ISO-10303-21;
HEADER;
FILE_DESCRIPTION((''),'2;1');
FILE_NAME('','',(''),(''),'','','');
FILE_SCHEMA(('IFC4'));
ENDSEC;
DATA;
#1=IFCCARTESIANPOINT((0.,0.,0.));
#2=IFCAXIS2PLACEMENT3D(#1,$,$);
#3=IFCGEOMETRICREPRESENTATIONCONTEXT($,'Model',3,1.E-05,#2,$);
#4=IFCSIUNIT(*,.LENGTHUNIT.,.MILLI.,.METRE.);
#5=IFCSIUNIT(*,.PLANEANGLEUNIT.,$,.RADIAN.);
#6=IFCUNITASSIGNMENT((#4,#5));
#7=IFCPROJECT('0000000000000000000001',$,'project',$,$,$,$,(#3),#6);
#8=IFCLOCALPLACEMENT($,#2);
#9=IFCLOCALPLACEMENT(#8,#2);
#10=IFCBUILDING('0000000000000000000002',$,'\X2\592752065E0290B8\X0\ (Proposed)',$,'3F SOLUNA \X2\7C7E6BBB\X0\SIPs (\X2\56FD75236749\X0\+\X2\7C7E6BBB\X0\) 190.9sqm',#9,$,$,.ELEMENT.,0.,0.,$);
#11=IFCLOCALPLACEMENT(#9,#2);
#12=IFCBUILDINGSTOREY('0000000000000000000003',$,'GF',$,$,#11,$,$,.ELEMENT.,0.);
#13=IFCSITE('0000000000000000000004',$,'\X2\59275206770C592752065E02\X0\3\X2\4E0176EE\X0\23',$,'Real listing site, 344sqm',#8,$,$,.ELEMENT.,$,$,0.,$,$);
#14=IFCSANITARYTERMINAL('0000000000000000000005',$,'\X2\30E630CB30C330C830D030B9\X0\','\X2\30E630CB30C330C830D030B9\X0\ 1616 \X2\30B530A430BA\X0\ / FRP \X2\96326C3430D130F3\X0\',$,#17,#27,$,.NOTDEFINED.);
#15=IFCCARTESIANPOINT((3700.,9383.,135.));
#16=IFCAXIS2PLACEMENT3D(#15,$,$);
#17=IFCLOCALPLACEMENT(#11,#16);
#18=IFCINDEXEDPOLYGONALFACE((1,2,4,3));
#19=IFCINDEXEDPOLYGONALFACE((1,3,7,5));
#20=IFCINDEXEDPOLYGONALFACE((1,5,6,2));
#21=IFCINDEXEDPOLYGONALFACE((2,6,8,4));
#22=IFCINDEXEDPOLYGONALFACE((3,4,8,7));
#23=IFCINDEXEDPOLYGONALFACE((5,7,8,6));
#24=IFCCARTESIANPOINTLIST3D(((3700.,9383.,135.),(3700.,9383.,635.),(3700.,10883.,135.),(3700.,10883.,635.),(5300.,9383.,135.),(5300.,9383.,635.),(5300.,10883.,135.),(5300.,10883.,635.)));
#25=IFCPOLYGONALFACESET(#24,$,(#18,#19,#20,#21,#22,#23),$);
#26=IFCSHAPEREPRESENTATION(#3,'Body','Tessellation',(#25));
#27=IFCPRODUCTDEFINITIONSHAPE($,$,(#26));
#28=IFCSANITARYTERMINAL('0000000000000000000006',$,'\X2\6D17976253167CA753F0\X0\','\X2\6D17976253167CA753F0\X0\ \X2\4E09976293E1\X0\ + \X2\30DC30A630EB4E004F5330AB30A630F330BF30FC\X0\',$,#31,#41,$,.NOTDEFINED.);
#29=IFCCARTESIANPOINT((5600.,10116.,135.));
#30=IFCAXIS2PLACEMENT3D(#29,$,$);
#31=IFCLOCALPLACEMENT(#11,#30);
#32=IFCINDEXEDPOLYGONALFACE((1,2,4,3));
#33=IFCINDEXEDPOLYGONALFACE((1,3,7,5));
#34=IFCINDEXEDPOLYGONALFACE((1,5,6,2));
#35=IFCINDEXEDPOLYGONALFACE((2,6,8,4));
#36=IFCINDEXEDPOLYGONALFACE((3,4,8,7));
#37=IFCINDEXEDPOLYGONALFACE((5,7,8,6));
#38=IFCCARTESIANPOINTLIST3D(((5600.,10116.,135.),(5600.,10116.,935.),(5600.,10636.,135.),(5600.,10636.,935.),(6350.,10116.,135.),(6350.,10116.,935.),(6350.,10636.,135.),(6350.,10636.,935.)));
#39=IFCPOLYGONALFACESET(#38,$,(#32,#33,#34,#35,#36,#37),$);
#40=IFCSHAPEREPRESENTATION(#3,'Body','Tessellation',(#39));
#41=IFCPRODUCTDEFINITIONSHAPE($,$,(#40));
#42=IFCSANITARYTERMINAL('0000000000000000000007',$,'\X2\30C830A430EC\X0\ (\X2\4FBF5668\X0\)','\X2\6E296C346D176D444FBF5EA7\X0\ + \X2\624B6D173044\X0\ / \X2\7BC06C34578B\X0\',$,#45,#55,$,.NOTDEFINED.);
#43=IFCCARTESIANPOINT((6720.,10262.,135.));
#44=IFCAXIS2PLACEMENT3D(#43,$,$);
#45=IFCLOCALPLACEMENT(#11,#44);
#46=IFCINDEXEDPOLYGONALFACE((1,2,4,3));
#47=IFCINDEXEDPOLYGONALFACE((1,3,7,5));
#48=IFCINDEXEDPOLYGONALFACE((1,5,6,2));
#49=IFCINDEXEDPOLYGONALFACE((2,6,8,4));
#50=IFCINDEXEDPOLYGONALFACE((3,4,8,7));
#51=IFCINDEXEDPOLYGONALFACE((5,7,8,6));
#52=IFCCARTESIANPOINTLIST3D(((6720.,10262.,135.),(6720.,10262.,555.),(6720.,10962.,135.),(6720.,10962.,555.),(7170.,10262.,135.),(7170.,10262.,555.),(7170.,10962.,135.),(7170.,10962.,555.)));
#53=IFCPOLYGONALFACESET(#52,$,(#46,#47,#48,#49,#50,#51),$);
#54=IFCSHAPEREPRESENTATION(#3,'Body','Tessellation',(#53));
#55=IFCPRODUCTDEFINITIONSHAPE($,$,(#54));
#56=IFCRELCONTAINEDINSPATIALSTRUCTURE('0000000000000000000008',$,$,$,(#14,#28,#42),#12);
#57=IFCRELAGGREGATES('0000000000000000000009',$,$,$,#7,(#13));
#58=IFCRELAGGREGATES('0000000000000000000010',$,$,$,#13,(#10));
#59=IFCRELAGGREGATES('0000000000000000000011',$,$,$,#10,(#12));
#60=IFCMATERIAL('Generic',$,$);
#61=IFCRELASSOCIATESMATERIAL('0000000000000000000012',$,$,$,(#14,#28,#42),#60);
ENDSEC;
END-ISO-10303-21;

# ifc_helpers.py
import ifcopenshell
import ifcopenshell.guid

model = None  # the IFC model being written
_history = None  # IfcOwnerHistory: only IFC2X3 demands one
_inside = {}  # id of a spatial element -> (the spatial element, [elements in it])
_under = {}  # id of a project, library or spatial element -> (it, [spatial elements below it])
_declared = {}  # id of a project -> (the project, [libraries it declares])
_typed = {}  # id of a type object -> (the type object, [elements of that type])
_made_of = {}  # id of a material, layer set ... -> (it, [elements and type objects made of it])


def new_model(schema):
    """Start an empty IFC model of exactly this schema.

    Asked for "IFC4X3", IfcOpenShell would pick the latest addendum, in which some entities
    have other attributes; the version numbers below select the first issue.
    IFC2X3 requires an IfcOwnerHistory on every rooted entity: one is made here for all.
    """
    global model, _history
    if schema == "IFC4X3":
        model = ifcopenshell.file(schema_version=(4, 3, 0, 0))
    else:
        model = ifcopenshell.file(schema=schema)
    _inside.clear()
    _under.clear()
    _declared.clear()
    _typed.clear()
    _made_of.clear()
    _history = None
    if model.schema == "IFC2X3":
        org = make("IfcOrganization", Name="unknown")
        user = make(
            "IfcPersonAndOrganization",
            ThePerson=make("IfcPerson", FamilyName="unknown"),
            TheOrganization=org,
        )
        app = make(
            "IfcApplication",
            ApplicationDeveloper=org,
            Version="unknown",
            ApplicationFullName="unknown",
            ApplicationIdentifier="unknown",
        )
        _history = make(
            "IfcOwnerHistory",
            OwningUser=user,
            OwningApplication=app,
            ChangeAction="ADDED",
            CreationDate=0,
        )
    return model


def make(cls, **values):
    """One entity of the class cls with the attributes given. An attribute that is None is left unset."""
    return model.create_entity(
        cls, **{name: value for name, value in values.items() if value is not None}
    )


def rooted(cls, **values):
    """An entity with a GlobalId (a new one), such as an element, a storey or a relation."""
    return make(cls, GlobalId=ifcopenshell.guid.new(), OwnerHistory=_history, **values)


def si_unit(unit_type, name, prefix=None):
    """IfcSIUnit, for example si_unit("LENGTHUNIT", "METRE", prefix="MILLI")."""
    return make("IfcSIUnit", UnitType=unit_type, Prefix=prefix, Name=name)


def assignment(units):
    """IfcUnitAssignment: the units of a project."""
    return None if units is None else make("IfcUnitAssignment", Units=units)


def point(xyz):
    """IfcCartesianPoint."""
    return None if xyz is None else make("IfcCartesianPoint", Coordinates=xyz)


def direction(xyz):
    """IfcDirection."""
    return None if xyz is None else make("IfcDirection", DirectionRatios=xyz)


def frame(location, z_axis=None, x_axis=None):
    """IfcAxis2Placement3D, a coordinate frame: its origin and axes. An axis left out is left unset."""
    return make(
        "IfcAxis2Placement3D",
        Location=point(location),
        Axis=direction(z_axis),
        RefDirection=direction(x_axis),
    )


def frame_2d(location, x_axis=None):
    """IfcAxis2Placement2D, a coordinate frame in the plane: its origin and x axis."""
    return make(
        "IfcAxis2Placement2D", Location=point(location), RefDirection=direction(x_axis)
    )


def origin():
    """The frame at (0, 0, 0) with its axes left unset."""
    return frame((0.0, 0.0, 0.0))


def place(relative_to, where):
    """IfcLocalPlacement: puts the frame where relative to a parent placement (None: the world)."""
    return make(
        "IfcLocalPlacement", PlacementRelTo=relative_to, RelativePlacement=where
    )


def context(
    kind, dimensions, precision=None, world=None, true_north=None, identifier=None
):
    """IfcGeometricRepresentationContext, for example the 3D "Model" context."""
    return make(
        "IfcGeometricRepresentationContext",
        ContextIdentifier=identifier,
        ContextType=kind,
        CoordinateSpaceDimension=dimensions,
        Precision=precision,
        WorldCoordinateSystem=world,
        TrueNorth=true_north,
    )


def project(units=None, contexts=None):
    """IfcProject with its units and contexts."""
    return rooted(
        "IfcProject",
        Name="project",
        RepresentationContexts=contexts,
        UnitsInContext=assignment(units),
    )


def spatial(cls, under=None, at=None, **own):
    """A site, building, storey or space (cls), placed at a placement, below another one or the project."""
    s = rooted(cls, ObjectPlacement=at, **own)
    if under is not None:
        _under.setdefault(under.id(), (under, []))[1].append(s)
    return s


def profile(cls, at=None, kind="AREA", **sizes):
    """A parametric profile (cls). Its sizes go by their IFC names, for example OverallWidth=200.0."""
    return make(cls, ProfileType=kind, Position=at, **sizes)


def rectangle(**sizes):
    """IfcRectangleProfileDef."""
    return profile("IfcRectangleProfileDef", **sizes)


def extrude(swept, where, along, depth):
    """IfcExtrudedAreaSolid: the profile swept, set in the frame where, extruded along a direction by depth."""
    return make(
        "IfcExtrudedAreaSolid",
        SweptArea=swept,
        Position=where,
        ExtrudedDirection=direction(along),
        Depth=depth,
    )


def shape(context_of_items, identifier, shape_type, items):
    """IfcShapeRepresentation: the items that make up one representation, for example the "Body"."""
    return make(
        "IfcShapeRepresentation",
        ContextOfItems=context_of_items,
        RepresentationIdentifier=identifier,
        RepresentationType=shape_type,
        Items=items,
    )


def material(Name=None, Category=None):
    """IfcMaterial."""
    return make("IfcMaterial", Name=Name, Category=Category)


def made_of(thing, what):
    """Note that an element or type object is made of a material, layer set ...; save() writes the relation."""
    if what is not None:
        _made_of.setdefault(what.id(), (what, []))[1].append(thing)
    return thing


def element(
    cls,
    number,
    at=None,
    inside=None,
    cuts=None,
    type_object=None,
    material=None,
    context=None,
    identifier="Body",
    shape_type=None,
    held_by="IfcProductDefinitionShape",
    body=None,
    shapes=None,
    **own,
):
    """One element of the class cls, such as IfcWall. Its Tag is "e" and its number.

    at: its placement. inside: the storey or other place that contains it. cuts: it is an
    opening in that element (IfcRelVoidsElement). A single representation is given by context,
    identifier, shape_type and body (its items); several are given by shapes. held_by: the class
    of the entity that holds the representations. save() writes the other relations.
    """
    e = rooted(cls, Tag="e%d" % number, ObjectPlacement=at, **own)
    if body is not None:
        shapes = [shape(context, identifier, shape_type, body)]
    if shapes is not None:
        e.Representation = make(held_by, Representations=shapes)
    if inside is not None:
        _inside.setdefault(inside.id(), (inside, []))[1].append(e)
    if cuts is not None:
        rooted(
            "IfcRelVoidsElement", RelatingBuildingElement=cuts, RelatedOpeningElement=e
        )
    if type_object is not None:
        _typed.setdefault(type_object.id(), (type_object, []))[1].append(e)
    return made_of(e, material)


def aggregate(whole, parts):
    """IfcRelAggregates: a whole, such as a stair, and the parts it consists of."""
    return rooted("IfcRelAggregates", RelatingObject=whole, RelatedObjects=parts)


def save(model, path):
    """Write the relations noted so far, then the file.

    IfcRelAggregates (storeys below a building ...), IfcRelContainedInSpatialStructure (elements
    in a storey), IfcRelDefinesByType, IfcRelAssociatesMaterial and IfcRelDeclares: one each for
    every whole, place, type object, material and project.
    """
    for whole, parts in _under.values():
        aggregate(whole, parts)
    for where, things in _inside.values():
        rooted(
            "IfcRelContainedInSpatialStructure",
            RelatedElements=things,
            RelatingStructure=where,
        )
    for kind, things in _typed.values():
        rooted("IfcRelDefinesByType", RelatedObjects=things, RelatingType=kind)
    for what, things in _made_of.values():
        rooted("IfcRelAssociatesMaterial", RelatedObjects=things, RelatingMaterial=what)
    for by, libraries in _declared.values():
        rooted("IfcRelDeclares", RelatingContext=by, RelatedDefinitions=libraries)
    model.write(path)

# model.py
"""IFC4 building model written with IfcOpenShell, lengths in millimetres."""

from ifc_helpers import new_model, si_unit, frame, frame_2d, origin, place, context, project, spatial, rectangle, extrude, material, element, save


model = new_model("IFC4")

# Units and contexts
model_context = context("Model", 3, precision=1e-05, world=origin())
ifc_project = project(units=[si_unit("LENGTHUNIT", "METRE", prefix="MILLI"), si_unit("PLANEANGLEUNIT", "RADIAN")], contexts=[model_context])

# Site, building, storey
site_placement = place(None, origin())
site = spatial("IfcSite", under=ifc_project, at=site_placement, Name="大分県大分市3丁目23", ObjectType="Real listing site, 344sqm", CompositionType="ELEMENT", RefElevation=0.0)
building_placement = place(site_placement, origin())
building = spatial("IfcBuilding", under=site, at=building_placement, Name="大分市邸 (Proposed)", ObjectType="3F SOLUNA 籾殻SIPs (国産杉+籾殻) 190.9sqm", CompositionType="ELEMENT", ElevationOfRefHeight=0.0, ElevationOfTerrain=0.0)
storey_placement = place(building_placement, origin())
storey = spatial("IfcBuildingStorey", under=building, at=storey_placement, Name="GF", CompositionType="ELEMENT", Elevation=0.0)

# Shared definitions
ifc_material_1 = material(Name="Generic")

# Sanitary terminals
sanitary_terminal_1_placement = place(storey_placement, frame((3700.0, 9383.0, 135.0)))
element("IfcSanitaryTerminal", 1, at=sanitary_terminal_1_placement, inside=storey, material=ifc_material_1, Name="ユニットバス", Description="ユニットバス 1616 サイズ / FRP 防水パン", PredefinedType="NOTDEFINED", context=model_context, shape_type="SweptSolid", body=[
    extrude(rectangle(XDim=1600.0, YDim=1500.0, at=frame_2d((800.0, 750.0))), frame((3700.0, 9383.0, 135.0)), (0.0, 0.0, 1.0), 500.0),
])
sanitary_terminal_2_placement = place(storey_placement, frame((5600.0, 10116.0, 135.0)))
element("IfcSanitaryTerminal", 2, at=sanitary_terminal_2_placement, inside=storey, material=ifc_material_1, Name="洗面化粧台", Description="洗面化粧台 三面鏡 + ボウル一体カウンター", PredefinedType="NOTDEFINED", context=model_context, shape_type="SweptSolid", body=[
    extrude(rectangle(XDim=750.0, YDim=520.0, at=frame_2d((375.0, 260.0))), frame((5600.0, 10116.0, 135.0)), (0.0, 0.0, 1.0), 800.0),
])
sanitary_terminal_3_placement = place(storey_placement, frame((6720.0, 10262.0, 135.0)))
element("IfcSanitaryTerminal", 3, at=sanitary_terminal_3_placement, inside=storey, material=ifc_material_1, Name="トイレ (便器)", Description="温水洗浄便座 + 手洗い / 節水型", PredefinedType="NOTDEFINED", context=model_context, shape_type="SweptSolid", body=[
    extrude(rectangle(XDim=450.0, YDim=700.0, at=frame_2d((225.0, 350.0))), frame((6720.0, 10262.0, 135.0)), (0.0, 0.0, 1.0), 420.0),
])

save(model, "model.ifc")
